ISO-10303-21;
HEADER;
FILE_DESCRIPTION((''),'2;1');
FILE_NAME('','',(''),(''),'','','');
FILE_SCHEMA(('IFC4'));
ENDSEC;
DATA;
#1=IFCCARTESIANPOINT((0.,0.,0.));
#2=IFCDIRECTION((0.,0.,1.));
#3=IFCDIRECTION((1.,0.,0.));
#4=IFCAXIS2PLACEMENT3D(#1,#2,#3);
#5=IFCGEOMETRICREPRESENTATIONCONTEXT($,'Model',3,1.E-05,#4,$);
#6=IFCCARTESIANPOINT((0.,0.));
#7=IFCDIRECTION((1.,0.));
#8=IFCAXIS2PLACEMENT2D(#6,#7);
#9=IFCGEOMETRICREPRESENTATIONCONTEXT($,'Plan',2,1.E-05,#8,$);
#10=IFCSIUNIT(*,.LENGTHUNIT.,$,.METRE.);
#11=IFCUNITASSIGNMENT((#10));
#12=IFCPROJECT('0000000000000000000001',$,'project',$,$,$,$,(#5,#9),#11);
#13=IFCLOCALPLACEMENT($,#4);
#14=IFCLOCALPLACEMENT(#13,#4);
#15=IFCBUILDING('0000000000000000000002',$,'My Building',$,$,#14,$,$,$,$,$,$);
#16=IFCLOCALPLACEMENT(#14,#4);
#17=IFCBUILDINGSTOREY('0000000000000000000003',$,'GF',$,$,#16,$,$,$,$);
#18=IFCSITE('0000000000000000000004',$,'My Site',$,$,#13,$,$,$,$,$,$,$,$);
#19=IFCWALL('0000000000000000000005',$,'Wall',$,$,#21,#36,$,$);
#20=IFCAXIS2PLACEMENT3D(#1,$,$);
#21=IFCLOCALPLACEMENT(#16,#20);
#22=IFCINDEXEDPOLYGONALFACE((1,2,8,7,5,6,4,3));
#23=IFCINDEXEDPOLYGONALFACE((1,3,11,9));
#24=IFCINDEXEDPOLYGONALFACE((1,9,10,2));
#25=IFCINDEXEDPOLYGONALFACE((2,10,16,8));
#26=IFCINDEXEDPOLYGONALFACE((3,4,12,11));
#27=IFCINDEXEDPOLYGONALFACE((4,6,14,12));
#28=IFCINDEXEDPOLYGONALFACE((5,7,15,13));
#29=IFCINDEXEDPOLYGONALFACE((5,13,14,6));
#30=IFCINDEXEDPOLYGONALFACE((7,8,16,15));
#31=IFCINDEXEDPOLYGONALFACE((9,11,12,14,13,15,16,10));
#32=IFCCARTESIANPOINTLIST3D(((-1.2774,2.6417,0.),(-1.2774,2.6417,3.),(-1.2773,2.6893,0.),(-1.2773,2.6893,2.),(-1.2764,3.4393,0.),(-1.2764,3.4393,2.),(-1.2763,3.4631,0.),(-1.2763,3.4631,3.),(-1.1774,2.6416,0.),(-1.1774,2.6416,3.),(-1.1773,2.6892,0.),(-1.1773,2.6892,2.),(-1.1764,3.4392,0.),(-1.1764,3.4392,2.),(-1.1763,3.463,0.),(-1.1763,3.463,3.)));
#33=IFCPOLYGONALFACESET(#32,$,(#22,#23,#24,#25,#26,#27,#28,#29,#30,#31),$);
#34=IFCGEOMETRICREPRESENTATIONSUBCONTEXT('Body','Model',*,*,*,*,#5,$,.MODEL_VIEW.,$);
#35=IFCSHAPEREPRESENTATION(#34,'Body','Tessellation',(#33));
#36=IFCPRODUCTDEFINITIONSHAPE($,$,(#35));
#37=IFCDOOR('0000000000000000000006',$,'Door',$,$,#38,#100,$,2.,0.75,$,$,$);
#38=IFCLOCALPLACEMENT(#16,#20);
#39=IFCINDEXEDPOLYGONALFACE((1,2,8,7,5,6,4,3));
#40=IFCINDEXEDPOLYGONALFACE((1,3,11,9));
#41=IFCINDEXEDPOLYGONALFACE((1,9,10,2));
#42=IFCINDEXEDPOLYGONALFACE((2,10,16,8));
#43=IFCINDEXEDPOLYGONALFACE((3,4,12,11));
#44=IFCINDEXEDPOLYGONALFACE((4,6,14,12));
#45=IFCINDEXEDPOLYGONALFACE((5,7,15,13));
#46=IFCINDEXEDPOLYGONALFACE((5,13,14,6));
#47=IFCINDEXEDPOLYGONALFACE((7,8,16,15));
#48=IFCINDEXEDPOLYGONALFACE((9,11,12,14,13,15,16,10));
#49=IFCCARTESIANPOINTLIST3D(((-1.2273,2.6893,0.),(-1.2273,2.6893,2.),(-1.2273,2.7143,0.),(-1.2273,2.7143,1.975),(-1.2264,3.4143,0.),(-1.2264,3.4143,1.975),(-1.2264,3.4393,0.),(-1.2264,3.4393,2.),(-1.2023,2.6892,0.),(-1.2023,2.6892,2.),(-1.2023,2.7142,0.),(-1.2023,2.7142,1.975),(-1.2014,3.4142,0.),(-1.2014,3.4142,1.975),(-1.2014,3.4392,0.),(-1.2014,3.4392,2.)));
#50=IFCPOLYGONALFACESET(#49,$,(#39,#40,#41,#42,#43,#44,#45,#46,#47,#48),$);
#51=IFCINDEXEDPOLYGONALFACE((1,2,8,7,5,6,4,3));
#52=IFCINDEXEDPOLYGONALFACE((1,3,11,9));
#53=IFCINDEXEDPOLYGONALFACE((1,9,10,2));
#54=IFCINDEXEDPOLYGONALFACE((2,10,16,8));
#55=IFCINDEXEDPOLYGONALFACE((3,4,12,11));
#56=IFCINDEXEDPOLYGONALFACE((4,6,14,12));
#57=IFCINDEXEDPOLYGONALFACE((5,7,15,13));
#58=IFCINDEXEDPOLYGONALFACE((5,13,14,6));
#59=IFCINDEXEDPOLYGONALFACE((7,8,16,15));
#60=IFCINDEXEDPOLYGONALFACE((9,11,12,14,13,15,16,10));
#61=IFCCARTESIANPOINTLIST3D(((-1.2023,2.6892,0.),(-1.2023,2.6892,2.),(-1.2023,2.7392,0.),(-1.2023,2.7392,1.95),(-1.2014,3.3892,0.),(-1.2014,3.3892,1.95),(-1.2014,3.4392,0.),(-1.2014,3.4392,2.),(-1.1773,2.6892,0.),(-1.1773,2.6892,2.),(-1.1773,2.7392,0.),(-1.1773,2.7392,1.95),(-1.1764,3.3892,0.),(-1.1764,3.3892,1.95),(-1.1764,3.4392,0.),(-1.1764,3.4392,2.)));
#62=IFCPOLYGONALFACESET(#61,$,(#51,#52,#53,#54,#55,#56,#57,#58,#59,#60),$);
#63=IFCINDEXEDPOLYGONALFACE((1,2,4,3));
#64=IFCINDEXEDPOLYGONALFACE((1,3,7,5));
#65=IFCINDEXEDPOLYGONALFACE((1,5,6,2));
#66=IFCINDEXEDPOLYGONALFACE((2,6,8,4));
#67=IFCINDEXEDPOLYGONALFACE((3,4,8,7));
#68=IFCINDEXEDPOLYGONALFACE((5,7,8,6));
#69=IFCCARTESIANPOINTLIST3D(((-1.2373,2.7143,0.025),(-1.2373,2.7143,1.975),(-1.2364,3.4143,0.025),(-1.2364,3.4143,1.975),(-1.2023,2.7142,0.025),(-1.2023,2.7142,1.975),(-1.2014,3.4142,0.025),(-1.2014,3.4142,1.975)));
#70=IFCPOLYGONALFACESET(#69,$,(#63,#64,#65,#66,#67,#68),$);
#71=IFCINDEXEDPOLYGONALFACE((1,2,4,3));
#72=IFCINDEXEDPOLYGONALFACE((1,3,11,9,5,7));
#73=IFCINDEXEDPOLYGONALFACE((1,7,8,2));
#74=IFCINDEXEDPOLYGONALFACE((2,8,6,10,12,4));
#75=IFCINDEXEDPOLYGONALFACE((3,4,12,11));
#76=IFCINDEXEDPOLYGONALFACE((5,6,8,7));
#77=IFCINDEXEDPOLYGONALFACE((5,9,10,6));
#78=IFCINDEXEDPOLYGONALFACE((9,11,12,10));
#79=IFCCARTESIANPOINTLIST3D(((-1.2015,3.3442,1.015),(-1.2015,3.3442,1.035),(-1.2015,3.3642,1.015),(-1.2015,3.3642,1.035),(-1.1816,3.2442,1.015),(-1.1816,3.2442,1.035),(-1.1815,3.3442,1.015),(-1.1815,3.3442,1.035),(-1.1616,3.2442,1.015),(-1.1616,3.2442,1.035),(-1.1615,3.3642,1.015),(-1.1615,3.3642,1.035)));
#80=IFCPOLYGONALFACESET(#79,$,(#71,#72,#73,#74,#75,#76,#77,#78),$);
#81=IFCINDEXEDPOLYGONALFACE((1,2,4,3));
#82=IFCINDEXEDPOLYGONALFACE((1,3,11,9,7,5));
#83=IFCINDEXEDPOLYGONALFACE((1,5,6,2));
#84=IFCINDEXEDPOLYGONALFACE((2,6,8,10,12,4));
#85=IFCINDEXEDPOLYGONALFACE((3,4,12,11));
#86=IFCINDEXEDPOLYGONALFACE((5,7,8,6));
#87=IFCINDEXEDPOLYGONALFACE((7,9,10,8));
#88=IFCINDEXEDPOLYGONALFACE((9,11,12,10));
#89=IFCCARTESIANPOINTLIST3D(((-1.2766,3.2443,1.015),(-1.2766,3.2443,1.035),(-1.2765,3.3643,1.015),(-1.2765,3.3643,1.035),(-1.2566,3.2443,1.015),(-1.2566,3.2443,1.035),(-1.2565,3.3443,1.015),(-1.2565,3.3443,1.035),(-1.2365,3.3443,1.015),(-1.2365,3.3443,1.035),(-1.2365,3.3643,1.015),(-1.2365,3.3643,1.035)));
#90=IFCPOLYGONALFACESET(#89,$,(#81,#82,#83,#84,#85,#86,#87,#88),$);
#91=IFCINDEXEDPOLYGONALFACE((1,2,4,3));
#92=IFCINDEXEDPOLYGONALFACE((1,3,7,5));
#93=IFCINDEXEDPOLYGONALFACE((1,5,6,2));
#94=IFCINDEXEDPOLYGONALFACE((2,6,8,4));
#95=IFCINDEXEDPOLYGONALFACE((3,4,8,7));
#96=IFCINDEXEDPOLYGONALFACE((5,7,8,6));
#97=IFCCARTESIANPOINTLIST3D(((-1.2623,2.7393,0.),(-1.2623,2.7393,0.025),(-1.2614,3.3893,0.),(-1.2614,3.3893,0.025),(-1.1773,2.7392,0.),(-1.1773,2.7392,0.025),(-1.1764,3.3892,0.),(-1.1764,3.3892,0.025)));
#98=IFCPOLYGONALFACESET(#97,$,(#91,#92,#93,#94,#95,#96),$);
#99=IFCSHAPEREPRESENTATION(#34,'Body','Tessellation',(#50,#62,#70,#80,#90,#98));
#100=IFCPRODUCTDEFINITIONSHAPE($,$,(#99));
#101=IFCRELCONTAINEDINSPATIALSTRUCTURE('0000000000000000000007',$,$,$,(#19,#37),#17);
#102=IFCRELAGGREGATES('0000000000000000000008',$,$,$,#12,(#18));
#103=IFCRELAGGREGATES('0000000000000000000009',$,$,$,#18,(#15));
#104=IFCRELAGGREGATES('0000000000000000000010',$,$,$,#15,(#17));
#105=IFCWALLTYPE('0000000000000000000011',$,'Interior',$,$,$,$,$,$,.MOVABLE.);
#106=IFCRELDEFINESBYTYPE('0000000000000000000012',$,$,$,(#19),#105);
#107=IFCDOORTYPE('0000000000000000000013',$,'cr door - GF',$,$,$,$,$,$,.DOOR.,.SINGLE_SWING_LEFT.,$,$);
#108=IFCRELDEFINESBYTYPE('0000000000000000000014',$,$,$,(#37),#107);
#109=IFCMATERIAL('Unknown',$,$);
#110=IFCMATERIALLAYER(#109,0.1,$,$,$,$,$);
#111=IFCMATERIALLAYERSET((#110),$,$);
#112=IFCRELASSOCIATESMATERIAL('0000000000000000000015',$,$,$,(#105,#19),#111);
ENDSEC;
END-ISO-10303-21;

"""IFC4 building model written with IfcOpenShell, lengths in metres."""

from ifc_helpers import new_model, entity, si_unit, frame, origin_with_axes, origin_2d_with_axis, place, context, subcontext, project, spatial, line, indexed_curve, outline, extrude, shape, source, transform, mapped, material, layer, layer_set, layer_usage, type_object, type_shapes, element, fill, save


model = new_model("IFC4")

# Units and contexts
model_context = context("Model", 3, precision=1e-05, world=origin_with_axes())
plan_context = context("Plan", 2, precision=1e-05, world=origin_2d_with_axis())
body_context_1 = subcontext(model_context, "Body", "Model", "MODEL_VIEW")
body_context_2 = subcontext(plan_context, "Body", "Plan", "PLAN_VIEW")
ifc_project = project(units=[si_unit("LENGTHUNIT", "METRE")], contexts=[model_context, plan_context])

# Site, building, storey
site_placement = place(None, origin_with_axes())
site = spatial("IfcSite", under=ifc_project, at=site_placement, Name="My Site")
building_placement = place(site_placement, origin_with_axes())
building = spatial("IfcBuilding", under=site, at=building_placement, Name="My Building")
storey_placement = place(building_placement, origin_with_axes())
storey = spatial("IfcBuildingStorey", under=building, at=storey_placement, Name="GF")

# Shared definitions
ifc_material = material(Name="Unknown")

# Shared definitions
ifc_layer_1 = layer(ifc_material, 0.1)
ifc_layer_set_1 = layer_set([ifc_layer_1])
wall_type_1 = type_object("IfcWallType", Name="Interior", PredefinedType="MOVABLE", material=ifc_layer_set_1)

# Wall, opening, door
ifc_layer_usage_1 = layer_usage(ifc_layer_set_1, "AXIS2", "POSITIVE", 0.0)
wall_1_placement = place(storey_placement, frame((-1.2763, 3.4631, 0.0), z_axis=(0.0, 0.0, 1.0), x_axis=(-0.001302, -0.999999, 0.0)))
wall_1 = element("IfcWall", 1, at=wall_1_placement, inside=storey, type_object=wall_type_1, material=ifc_layer_usage_1, Name="Wall", context=body_context_1, shape_type="SweptSolid", body=[
    extrude(outline(indexed_curve([(0.0, 0.0), (0.0, 0.1), (0.8215, 0.1), (0.8215, 0.0)], segments=[line(1, 2, 3, 4, 1)])), origin_with_axes(), (0.0, 0.0, 1.0), 3.0),
])
shared_shape_1 = source(origin_with_axes(), body_context_1, "Body", "SweptSolid", [
    extrude(outline(indexed_curve([(0.0, 0.0), (0.75, 0.0), (0.75, 2.0), (0.0, 2.0)], segments=[line(1, 2, 3, 4, 1)])), frame((0.0, -0.6, 0.0), z_axis=(0.0, -1.0, 0.0), x_axis=(1.0, 0.0, 0.0)), (0.0, 0.0, -1.0), 1.2),
])
opening_1_placement = place(wall_1_placement, frame((0.7738, 0.1, 0.0), z_axis=(0.0, 0.0, 1.0), x_axis=(-1.0, 0.0, 0.0)))
opening_1 = element("IfcOpeningElement", 2, at=opening_1_placement, cuts=wall_1, PredefinedType="OPENING", context=body_context_1, shape_type="MappedRepresentation", body=[
    mapped(shared_shape_1, transform((0.0, 0.0, 0.0), x_axis=(1.0, 0.0, 0.0), y_axis=(0.0, 1.0, 0.0), z_axis=(0.0, 0.0, 1.0), scale=1.0)),
])
door_type_1 = type_object("IfcDoorType", Name="cr door - GF", OperationType="SINGLE_SWING_LEFT", PredefinedType="DOOR")
shared_shape_2 = source(origin_with_axes(), body_context_1, "Body", "SweptSolid", [
    extrude(outline(indexed_curve([(0.0, 0.0), (0.0, 2.0), (0.75, 2.0), (0.75, 0.0), (0.725, 0.0), (0.725, 1.975), (0.025, 1.975), (0.025, 0.0)], segments=[line(1, 2, 3, 4, 5, 6, 7, 8, 1)])), frame((0.0, 0.025, 0.0), z_axis=(0.0, -1.0, 0.0), x_axis=(1.0, 0.0, 0.0)), (0.0, 0.0, -1.0), 0.025),
    extrude(outline(indexed_curve([(0.0, 0.0), (0.0, 2.0), (0.75, 2.0), (0.75, 0.0), (0.7, 0.0), (0.7, 1.95), (0.05, 1.95), (0.05, 0.0)], segments=[line(1, 2, 3, 4, 5, 6, 7, 8, 1)])), frame((0.0, 0.0, 0.0), z_axis=(0.0, -1.0, 0.0), x_axis=(1.0, 0.0, 0.0)), (0.0, 0.0, -1.0), 0.025),
    extrude(outline(indexed_curve([(0.0, 0.0), (0.7, 0.0), (0.7, 0.035), (0.0, 0.035)], segments=[line(1, 2, 3, 4, 1)])), frame((0.025, 0.025, 0.025), z_axis=(0.0, 0.0, 1.0), x_axis=(1.0, 0.0, 0.0)), (0.0, 0.0, 1.0), 1.95),
    extrude(outline(indexed_curve([(0.0, 0.0), (0.0, -0.04), (-0.12, -0.04), (-0.12, -0.02), (-0.02, -0.02), (-0.02, 0.0)], segments=[line(1, 2, 3, 4, 5, 6, 1)])), frame((0.675, 0.025, 1.015), z_axis=(0.0, 0.0, 1.0), x_axis=(1.0, 0.0, 0.0)), (0.0, 0.0, 1.0), 0.02),
    extrude(outline(indexed_curve([(0.0, 0.0), (0.0, 0.04), (-0.12, 0.04), (-0.12, 0.02), (-0.02, 0.02), (-0.02, 0.0)], segments=[line(1, 2, 3, 4, 5, 6, 1)])), frame((0.675, 0.06, 1.015), z_axis=(0.0, 0.0, 1.0), x_axis=(1.0, 0.0, 0.0)), (0.0, 0.0, 1.0), 0.02),
    extrude(outline(indexed_curve([(0.0, 0.0), (0.65, 0.0), (0.65, 0.085), (0.0, 0.085)], segments=[line(1, 2, 3, 4, 1)])), frame((0.05, 0.0, 0.0), z_axis=(0.0, 0.0, 1.0), x_axis=(1.0, 0.0, 0.0)), (0.0, 0.0, 1.0), 0.025),
])
shared_shape_3 = source(origin_with_axes(), body_context_2, "Body", "Curve2D", [
    entity("IfcIndexedPolyCurve", entity("IfcCartesianPointList2D", [[0.0, 0.0], [0.0, 0.05], [0.025, 0.05], [0.025, 0.025], [0.05, 0.025], [0.05, 0.0]]), [entity("IfcLineIndex", [1, 2, 3, 4, 5, 6, 1])]),
    entity("IfcIndexedPolyCurve", entity("IfcCartesianPointList2D", [[0.75, 0.0], [0.75, 0.05], [0.725, 0.05], [0.725, 0.025], [0.7, 0.025], [0.7, 0.0]]), [entity("IfcLineIndex", [1, 2, 3, 4, 5, 6, 1])]),
    entity("IfcTrimmedCurve", entity("IfcEllipse", entity("IfcAxis2Placement2D", entity("IfcCartesianPoint", [0.06, 0.05]), entity("IfcDirection", [1.0, 0.0])), 0.665, 0.7), [entity("IfcCartesianPoint", [0.725, 0.05])], [entity("IfcCartesianPoint", [0.06, 0.75])], True, "CARTESIAN"),
    entity("IfcIndexedPolyCurve", entity("IfcCartesianPointList2D", [[0.025, 0.05], [0.06, 0.05], [0.06, 0.75], [0.025, 0.75]]), [entity("IfcLineIndex", [1, 2, 3, 4, 1])]),
])
type_shapes(door_type_1, [shared_shape_2, shared_shape_3])
door_1_placement = place(opening_1_placement, frame((0.0, 0.0, 0.0), z_axis=(0.0, 0.0, 1.0), x_axis=(1.0, 0.0, 0.0)))
door_1 = element("IfcDoor", 3, at=door_1_placement, inside=storey, type_object=door_type_1, Name="Door", OverallHeight=2.0, OverallWidth=0.75, shapes=[
    shape(body_context_1, "Body", "MappedRepresentation", [mapped(shared_shape_2, transform((0.0, 0.0, 0.0), x_axis=(1.0, 0.0, 0.0), y_axis=(0.0, 1.0, 0.0), z_axis=(0.0, 0.0, 1.0), scale=1.0))]),
    shape(body_context_2, "Body", "MappedRepresentation", [mapped(shared_shape_3, transform((0.0, 0.0, 0.0), x_axis=(1.0, 0.0, 0.0), y_axis=(0.0, 1.0, 0.0), z_axis=(0.0, 0.0, 1.0), scale=1.0))]),
])
fill(opening_1, door_1)

save(model, "model.ifc")
